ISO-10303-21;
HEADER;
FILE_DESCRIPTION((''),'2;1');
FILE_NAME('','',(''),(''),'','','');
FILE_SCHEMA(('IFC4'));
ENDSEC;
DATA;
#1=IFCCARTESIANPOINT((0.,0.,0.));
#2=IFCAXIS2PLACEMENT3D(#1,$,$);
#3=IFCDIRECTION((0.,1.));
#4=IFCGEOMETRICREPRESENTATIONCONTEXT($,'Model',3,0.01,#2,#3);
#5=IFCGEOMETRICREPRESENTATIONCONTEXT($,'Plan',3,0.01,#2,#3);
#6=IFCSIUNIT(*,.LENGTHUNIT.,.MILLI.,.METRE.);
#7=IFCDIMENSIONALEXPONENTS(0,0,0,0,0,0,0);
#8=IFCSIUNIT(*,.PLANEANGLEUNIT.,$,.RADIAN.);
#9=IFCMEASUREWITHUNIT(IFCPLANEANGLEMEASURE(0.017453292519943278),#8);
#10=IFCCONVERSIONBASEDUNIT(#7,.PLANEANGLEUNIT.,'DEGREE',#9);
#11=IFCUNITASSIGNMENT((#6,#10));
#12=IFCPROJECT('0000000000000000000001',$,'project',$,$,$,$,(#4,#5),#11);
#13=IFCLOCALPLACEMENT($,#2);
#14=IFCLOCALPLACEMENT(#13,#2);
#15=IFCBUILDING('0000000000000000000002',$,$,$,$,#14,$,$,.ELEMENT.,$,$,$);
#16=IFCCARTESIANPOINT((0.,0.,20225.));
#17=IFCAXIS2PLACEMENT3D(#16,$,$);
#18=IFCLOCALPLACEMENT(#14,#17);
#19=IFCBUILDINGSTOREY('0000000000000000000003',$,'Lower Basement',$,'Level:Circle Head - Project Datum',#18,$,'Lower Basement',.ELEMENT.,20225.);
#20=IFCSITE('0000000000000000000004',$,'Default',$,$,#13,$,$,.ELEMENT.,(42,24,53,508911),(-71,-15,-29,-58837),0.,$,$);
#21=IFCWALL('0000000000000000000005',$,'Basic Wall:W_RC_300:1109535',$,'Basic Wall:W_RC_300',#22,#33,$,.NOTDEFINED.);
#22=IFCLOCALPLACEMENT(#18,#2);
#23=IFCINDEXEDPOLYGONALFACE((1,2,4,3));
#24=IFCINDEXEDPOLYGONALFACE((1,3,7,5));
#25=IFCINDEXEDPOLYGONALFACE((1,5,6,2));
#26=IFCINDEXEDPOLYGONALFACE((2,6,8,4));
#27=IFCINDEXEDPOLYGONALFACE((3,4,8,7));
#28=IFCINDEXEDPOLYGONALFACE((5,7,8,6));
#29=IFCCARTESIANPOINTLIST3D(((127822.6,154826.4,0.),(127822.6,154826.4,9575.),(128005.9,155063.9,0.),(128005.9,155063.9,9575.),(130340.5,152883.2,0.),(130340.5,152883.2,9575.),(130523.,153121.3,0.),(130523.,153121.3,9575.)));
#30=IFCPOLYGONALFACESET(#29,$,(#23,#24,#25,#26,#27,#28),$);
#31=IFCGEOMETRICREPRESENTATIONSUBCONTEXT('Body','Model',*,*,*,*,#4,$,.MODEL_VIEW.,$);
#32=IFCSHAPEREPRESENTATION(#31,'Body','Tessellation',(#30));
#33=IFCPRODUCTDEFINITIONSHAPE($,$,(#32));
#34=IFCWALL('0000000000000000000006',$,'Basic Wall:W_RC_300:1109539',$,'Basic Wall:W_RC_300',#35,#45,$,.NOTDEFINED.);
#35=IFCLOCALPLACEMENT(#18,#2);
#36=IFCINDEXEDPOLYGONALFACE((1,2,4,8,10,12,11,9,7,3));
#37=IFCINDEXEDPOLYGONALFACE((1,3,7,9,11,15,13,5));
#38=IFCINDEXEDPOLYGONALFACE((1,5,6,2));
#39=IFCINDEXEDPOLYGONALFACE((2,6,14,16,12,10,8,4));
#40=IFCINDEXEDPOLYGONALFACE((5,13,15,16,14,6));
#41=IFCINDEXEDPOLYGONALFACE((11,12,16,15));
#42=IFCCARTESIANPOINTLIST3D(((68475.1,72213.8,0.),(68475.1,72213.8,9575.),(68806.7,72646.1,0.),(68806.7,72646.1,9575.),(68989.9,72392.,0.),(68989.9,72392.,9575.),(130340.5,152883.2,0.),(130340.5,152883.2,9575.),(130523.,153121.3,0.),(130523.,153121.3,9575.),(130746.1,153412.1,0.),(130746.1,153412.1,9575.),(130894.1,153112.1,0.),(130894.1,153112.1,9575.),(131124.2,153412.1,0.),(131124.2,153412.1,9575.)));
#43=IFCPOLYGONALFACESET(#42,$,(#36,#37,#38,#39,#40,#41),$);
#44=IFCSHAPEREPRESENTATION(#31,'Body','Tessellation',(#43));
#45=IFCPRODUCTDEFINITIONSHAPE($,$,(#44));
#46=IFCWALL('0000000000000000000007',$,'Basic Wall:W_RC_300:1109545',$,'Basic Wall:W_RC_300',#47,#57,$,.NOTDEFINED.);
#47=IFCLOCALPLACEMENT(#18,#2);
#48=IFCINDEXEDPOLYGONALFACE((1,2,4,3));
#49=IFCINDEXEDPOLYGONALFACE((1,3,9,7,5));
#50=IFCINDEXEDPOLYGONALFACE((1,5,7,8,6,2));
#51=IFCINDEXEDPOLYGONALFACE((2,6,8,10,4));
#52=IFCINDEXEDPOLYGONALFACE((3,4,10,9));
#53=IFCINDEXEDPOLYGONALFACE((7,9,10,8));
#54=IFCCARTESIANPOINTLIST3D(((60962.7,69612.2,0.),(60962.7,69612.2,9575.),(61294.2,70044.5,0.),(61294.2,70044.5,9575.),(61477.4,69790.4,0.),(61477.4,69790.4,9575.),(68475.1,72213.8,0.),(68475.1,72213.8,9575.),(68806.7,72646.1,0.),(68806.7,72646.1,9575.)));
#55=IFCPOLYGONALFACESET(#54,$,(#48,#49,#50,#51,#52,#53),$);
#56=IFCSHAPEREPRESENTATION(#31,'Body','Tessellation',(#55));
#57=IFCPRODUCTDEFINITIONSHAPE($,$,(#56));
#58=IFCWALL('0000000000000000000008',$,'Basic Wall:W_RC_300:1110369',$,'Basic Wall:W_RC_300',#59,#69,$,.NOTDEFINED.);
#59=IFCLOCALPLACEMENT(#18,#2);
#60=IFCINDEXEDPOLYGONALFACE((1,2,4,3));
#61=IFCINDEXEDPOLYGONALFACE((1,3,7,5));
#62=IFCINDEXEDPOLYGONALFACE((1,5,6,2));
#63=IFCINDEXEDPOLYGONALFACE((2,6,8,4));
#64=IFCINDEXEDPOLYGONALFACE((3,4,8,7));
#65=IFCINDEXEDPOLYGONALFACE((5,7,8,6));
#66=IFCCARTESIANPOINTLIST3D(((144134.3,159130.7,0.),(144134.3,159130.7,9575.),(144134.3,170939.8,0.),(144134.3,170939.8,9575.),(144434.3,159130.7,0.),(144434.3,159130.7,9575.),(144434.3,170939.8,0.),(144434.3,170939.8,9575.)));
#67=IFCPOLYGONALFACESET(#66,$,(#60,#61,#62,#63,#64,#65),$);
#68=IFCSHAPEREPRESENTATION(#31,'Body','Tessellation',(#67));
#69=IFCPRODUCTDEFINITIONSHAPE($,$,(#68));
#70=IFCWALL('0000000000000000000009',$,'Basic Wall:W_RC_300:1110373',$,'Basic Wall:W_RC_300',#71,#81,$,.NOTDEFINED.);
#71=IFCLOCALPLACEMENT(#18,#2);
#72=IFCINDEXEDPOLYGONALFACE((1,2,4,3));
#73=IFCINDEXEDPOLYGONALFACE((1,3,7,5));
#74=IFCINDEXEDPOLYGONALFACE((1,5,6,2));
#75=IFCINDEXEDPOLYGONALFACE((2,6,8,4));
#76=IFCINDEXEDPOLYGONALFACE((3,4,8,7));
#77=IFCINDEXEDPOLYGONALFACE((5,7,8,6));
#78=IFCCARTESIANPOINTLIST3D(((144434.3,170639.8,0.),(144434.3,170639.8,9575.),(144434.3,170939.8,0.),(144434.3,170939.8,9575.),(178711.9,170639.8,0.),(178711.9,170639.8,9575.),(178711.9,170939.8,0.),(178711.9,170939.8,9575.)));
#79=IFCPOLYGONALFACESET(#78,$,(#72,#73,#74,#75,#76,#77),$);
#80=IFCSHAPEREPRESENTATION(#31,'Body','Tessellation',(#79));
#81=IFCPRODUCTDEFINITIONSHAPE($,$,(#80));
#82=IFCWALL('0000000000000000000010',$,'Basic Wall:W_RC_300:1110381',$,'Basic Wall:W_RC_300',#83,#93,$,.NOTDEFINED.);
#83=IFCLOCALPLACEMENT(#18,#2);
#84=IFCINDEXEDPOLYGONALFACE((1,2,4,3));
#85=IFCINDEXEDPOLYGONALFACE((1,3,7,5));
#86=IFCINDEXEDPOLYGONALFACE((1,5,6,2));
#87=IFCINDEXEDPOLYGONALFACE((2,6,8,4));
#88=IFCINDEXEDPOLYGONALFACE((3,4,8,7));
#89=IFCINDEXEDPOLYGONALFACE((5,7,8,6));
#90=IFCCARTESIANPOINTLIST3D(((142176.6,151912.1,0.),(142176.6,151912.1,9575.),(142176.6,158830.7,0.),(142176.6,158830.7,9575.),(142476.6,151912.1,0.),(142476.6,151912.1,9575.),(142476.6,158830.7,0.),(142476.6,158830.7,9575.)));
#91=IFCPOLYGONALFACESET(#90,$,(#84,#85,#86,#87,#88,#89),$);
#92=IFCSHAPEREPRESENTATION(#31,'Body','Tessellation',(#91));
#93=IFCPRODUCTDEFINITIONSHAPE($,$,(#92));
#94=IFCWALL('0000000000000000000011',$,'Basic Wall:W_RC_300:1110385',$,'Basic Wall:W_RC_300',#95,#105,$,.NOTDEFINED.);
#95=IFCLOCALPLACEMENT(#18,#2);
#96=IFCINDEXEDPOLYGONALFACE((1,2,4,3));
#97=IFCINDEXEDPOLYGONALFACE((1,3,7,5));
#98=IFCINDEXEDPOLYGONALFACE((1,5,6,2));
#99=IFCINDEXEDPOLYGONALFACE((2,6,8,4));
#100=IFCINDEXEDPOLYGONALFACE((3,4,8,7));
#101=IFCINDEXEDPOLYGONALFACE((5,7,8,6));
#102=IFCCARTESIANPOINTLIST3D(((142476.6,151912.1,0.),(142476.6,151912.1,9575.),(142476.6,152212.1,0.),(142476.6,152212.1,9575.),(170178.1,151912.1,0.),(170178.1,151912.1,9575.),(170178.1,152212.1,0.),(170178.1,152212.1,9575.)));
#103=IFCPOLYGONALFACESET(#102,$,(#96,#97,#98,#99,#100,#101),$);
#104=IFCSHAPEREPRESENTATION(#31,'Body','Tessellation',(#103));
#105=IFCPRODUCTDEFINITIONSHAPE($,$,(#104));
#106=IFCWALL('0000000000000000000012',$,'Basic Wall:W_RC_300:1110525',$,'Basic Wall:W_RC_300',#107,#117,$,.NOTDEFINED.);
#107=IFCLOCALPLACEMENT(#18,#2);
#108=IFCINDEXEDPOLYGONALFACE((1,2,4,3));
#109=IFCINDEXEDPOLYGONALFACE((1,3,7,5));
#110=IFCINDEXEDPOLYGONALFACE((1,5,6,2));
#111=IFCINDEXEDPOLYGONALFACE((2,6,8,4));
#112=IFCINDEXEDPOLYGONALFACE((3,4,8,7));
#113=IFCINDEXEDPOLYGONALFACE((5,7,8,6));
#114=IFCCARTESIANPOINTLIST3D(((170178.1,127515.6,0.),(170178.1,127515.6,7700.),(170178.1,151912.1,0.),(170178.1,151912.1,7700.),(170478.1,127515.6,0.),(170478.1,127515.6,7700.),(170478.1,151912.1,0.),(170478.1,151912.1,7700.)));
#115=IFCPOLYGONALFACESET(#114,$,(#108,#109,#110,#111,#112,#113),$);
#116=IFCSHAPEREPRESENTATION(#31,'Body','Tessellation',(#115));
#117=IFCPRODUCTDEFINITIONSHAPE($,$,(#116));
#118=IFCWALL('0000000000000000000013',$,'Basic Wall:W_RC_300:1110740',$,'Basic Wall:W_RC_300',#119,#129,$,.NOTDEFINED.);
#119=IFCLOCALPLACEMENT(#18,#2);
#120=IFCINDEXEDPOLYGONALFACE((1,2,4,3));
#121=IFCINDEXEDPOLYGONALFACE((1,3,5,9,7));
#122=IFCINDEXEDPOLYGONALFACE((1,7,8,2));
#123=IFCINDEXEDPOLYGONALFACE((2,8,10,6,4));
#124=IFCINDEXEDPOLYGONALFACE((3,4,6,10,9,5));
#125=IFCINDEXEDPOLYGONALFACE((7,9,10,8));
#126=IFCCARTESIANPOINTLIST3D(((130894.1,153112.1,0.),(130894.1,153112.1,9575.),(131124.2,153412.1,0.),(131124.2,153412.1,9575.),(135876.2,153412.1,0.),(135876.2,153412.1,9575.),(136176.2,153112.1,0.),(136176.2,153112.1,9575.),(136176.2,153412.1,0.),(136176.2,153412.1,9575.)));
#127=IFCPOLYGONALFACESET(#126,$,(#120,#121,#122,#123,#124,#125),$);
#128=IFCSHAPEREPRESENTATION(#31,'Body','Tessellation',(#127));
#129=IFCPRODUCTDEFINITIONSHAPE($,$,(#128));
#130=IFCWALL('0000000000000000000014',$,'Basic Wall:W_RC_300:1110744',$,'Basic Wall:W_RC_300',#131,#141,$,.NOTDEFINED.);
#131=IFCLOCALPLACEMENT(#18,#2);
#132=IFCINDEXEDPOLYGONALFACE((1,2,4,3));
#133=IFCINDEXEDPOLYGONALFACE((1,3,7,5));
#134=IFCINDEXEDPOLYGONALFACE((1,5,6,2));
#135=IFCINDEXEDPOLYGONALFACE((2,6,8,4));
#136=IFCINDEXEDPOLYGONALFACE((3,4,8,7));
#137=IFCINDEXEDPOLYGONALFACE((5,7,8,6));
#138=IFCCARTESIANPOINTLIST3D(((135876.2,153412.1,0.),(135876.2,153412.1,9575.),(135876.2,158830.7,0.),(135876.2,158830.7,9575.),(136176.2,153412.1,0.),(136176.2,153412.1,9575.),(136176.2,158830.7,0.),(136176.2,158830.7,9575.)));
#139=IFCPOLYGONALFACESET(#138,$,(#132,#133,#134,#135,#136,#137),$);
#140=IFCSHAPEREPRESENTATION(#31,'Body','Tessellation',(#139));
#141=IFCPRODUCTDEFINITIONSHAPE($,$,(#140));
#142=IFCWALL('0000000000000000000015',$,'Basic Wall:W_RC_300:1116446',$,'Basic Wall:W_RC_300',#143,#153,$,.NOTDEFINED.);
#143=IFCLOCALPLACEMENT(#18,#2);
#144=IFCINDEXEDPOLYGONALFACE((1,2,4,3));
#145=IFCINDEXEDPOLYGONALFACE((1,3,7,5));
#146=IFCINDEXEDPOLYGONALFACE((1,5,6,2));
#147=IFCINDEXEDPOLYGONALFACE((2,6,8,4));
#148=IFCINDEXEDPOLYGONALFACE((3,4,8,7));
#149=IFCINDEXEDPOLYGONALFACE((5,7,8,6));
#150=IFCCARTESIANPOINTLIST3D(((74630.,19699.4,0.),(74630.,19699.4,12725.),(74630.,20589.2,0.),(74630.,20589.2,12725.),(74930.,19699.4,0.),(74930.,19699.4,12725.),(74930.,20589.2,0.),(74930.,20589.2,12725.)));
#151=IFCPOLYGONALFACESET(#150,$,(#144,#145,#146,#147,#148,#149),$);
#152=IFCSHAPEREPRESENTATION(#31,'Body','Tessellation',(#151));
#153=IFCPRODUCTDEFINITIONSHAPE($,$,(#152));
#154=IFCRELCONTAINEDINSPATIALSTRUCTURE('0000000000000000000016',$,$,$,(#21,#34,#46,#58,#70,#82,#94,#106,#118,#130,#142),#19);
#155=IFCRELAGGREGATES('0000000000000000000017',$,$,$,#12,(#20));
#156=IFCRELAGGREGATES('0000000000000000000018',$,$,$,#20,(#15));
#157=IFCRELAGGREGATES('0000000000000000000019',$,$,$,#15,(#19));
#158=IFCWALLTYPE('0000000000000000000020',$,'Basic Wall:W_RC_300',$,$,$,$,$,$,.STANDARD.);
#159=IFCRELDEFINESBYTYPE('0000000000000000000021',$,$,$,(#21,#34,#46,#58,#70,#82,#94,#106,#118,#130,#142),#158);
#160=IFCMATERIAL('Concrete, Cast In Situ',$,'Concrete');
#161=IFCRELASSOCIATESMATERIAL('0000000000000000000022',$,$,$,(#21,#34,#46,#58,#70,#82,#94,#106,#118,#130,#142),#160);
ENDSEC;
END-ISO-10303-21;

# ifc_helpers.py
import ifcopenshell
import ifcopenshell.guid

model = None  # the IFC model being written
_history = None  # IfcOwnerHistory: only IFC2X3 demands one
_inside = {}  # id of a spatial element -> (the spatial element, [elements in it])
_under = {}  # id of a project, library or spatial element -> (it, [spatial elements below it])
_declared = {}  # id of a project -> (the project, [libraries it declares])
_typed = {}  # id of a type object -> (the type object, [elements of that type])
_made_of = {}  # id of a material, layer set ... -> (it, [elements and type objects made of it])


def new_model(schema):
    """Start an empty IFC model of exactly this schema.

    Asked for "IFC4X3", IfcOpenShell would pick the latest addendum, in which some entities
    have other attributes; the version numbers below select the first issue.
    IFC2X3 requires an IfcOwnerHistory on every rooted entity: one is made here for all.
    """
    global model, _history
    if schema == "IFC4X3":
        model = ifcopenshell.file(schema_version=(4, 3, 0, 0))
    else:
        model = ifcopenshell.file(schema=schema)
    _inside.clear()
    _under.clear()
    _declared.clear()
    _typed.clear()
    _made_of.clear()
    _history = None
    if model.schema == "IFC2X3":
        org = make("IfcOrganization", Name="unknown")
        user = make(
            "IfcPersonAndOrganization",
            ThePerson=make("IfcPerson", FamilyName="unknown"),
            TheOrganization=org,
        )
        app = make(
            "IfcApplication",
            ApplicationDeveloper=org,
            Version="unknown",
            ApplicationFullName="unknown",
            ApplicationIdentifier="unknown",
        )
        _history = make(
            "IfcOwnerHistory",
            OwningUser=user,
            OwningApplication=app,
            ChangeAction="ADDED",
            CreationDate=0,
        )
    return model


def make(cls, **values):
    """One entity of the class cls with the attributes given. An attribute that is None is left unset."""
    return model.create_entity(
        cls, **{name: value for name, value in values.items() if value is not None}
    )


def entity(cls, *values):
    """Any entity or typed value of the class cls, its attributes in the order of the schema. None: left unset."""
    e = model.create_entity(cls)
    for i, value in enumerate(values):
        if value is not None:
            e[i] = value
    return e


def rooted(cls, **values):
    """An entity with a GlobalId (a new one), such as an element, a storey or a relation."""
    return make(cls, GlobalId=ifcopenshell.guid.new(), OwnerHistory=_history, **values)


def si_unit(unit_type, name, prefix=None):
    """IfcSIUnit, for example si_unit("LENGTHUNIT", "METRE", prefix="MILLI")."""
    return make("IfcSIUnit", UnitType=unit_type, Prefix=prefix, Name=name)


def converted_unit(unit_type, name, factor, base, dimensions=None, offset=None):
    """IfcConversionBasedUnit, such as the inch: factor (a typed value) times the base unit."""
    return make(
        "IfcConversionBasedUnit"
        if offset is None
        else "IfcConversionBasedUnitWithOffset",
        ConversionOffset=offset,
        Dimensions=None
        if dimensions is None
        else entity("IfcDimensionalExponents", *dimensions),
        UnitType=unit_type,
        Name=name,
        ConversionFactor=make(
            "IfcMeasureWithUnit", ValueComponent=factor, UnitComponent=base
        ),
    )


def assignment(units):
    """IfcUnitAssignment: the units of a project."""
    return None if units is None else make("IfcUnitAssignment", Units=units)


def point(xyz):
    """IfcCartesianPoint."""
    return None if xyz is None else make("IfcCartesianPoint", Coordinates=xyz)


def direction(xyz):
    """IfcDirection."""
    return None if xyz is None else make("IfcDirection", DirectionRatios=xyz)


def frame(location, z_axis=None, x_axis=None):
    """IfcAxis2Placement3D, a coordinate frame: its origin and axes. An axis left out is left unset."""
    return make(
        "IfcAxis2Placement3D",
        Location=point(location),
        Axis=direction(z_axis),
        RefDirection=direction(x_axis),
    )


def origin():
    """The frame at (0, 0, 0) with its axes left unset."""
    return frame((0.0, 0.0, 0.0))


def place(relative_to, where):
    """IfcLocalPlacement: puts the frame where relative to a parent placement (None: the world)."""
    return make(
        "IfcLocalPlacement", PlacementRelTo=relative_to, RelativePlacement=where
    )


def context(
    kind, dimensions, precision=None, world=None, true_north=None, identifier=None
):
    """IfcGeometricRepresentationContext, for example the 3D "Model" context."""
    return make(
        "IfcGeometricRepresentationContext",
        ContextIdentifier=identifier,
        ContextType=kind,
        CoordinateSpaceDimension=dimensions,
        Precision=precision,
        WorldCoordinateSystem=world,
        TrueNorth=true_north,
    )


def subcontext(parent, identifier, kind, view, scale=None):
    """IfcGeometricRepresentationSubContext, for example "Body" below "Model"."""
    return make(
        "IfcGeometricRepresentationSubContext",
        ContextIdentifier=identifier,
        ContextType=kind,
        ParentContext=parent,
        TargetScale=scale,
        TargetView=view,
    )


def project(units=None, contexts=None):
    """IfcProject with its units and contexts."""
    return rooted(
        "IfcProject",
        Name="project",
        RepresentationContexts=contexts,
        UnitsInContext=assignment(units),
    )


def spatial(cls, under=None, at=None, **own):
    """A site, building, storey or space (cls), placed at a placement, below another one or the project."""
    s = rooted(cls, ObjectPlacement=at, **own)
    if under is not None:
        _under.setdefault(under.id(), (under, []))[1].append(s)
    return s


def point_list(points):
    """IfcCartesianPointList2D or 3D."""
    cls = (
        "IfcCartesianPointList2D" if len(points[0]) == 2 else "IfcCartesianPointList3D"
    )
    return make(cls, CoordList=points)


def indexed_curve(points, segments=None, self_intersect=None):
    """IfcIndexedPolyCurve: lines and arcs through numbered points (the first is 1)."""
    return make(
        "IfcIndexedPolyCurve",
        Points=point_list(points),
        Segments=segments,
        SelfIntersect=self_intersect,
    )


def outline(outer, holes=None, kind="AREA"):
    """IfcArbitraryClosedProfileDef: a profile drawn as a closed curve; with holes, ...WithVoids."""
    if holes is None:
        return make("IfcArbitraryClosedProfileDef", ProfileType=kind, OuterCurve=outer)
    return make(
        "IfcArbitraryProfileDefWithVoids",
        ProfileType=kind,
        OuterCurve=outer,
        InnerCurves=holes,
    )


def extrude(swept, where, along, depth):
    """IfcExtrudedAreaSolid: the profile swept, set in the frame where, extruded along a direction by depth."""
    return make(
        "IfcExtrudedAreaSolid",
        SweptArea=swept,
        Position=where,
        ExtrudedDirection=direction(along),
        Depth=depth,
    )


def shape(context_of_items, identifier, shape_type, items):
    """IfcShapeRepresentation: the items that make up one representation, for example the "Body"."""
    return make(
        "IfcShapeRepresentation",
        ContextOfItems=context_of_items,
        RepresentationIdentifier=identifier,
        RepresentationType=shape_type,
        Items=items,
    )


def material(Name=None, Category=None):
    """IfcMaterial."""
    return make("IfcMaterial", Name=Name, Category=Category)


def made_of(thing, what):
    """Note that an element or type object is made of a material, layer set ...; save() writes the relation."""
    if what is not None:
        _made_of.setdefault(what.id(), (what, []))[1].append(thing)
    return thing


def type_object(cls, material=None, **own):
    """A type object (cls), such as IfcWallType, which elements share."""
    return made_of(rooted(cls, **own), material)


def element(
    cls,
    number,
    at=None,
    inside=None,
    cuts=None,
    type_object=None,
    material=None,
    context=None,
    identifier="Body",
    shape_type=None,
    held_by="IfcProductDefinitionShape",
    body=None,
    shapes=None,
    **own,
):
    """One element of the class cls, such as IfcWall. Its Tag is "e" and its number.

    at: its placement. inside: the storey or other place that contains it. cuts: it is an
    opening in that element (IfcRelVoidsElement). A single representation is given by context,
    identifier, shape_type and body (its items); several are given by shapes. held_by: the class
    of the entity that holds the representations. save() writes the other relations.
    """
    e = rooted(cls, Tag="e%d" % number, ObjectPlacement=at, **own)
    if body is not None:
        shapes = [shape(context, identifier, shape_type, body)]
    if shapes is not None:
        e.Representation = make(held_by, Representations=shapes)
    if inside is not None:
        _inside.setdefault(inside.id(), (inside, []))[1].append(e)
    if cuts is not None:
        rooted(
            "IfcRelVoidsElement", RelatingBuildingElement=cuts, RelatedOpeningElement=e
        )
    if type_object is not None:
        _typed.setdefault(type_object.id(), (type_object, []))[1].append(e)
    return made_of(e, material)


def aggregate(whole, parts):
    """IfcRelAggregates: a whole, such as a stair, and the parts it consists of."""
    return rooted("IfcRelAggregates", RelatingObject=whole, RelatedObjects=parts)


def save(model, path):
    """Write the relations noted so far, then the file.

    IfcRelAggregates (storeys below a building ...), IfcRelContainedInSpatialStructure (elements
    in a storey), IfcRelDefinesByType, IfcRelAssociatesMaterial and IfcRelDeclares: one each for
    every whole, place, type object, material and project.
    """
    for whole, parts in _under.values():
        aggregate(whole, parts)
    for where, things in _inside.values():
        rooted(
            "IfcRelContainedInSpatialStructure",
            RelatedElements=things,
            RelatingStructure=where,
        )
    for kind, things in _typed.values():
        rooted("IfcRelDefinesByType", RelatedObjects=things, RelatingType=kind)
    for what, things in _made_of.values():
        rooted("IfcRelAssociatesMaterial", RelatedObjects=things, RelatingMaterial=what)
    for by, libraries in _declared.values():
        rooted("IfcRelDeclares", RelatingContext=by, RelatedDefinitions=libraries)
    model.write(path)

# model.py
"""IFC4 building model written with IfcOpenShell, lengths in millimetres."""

from ifc_helpers import new_model, entity, si_unit, converted_unit, direction, frame, origin, place, context, subcontext, project, spatial, indexed_curve, outline, extrude, material, type_object, element, save


model = new_model("IFC4")

# Units and contexts
model_context = context("Model", 3, precision=0.01, world=origin(), true_north=direction((0.0, 1.0)))
plan_context = context("Plan", 3, precision=0.01, world=origin(), true_north=direction((0.0, 1.0)))
body_context = subcontext(model_context, "Body", "Model", "MODEL_VIEW")
ifc_project = project(units=[si_unit("LENGTHUNIT", "METRE", prefix="MILLI"), converted_unit("PLANEANGLEUNIT", "DEGREE", entity("IfcPlaneAngleMeasure", 0.017453292519943278), si_unit("PLANEANGLEUNIT", "RADIAN"), dimensions=[0, 0, 0, 0, 0, 0, 0])], contexts=[model_context, plan_context])

# Site, building, storey
site_placement = place(None, origin())
site = spatial("IfcSite", under=ifc_project, at=site_placement, Name="Default", CompositionType="ELEMENT", RefLatitude=(42, 24, 53, 508911), RefLongitude=(-71, -15, -29, -58837), RefElevation=0.0)
building_placement = place(site_placement, origin())
building = spatial("IfcBuilding", under=site, at=building_placement, CompositionType="ELEMENT")
storey_placement = place(building_placement, frame((0.0, 0.0, 20225.0)))
storey = spatial("IfcBuildingStorey", under=building, at=storey_placement, Name="Lower Basement", ObjectType="Level:Circle Head - Project Datum", LongName="Lower Basement", CompositionType="ELEMENT", Elevation=20225.0)

# Walls
ifc_material_1 = material(Name="Concrete, Cast In Situ", Category="Concrete")
wall_type_1 = type_object("IfcWallType", Name="Basic Wall:W_RC_300", PredefinedType="STANDARD")
wall_1_placement = place(storey_placement, frame((130432.1, 153001.9, 0.0), z_axis=(0.0, 0.0, 1.0), x_axis=(-0.791654, 0.61097, 0.0)))
element("IfcWall", 1, at=wall_1_placement, inside=storey, type_object=wall_type_1, material=ifc_material_1, Name="Basic Wall:W_RC_300:1109535", ObjectType="Basic Wall:W_RC_300", PredefinedType="NOTDEFINED", context=body_context, shape_type="SweptSolid", body=[
    extrude(outline(indexed_curve([(3180.5, -150.0), (3180.5, 150.0), (0.0, 150.0), (0.9, -150.0), (3180.5, -150.0)], self_intersect=False)), origin(), (0.0, 0.0, 1.0), 9575.0),
])
wall_2_placement = place(storey_placement, frame((68594.2, 72122.5, 0.0), z_axis=(0.0, 0.0, 1.0), x_axis=(0.608548, 0.793517, 0.0)))
element("IfcWall", 2, at=wall_2_placement, inside=storey, type_object=wall_type_1, material=ifc_material_1, Name="Basic Wall:W_RC_300:1109539", ObjectType="Basic Wall:W_RC_300", PredefinedType="NOTDEFINED", context=body_context, shape_type="SweptSolid", body=[
    extrude(outline(indexed_curve([(102557.2, -150.0), (102327.2, 150.0), (101960.6, 150.0), (101660.6, 150.0), (544.8, 150.0), (0.0, 150.0), (454.7, -150.0), (102179.2, -150.0), (102557.2, -150.0)], self_intersect=False)), origin(), (0.0, 0.0, 1.0), 9575.0),
])
wall_3_placement = place(storey_placement, frame((60913.6, 69753.9, 0.0), z_axis=(0.0, 0.0, 1.0), x_axis=(0.944942, 0.327236, 0.0)))
element("IfcWall", 3, at=wall_3_placement, inside=storey, type_object=wall_type_1, material=ifc_material_1, Name="Basic Wall:W_RC_300:1109545", ObjectType="Basic Wall:W_RC_300", PredefinedType="NOTDEFINED", context=body_context, shape_type="SweptSolid", body=[
    extrude(outline(indexed_curve([(7950.2, -150.0), (8404.9, 150.0), (454.7, 150.0), (0.0, -150.0), (544.7, -150.0), (7950.2, -150.0)], self_intersect=False)), origin(), (0.0, 0.0, 1.0), 9575.0),
])
wall_4_placement = place(storey_placement, frame((144284.3, 159130.7, 0.0), z_axis=(0.0, 0.0, 1.0), x_axis=(0.0, 1.0, 0.0)))
element("IfcWall", 4, at=wall_4_placement, inside=storey, type_object=wall_type_1, material=ifc_material_1, Name="Basic Wall:W_RC_300:1110369", ObjectType="Basic Wall:W_RC_300", PredefinedType="NOTDEFINED", context=body_context, shape_type="SweptSolid", body=[
    extrude(outline(indexed_curve([(11809.1, 150.0), (0.0, 150.0), (0.0, -150.0), (11809.1, -150.0), (11809.1, 150.0)], self_intersect=False)), origin(), (0.0, 0.0, 1.0), 9575.0),
])
wall_5_placement = place(storey_placement, frame((144434.3, 170789.8, 0.0)))
element("IfcWall", 5, at=wall_5_placement, inside=storey, type_object=wall_type_1, material=ifc_material_1, Name="Basic Wall:W_RC_300:1110373", ObjectType="Basic Wall:W_RC_300", PredefinedType="NOTDEFINED", context=body_context, shape_type="SweptSolid", body=[
    extrude(outline(indexed_curve([(34277.6, 150.0), (0.0, 150.0), (0.0, -150.0), (34277.6, -150.0), (34277.6, 150.0)], self_intersect=False)), origin(), (0.0, 0.0, 1.0), 9575.0),
])
wall_6_placement = place(storey_placement, frame((142326.6, 151912.1, 0.0), z_axis=(0.0, 0.0, 1.0), x_axis=(0.0, 1.0, 0.0)))
element("IfcWall", 6, at=wall_6_placement, inside=storey, type_object=wall_type_1, material=ifc_material_1, Name="Basic Wall:W_RC_300:1110381", ObjectType="Basic Wall:W_RC_300", PredefinedType="NOTDEFINED", context=body_context, shape_type="SweptSolid", body=[
    extrude(outline(indexed_curve([(6918.6, 150.0), (0.0, 150.0), (0.0, -150.0), (6918.6, -150.0), (6918.6, 150.0)], self_intersect=False)), origin(), (0.0, 0.0, 1.0), 9575.0),
])
wall_7_placement = place(storey_placement, frame((170178.1, 152062.1, 0.0), z_axis=(0.0, 0.0, 1.0), x_axis=(-1.0, 0.0, 0.0)))
element("IfcWall", 7, at=wall_7_placement, inside=storey, type_object=wall_type_1, material=ifc_material_1, Name="Basic Wall:W_RC_300:1110385", ObjectType="Basic Wall:W_RC_300", PredefinedType="NOTDEFINED", context=body_context, shape_type="SweptSolid", body=[
    extrude(outline(indexed_curve([(27701.5, 150.0), (0.0, 150.0), (0.0, -150.0), (27701.5, -150.0), (27701.5, 150.0)], self_intersect=False)), origin(), (0.0, 0.0, 1.0), 9575.0),
])
wall_8_placement = place(storey_placement, frame((170328.1, 127515.6, 0.0), z_axis=(0.0, 0.0, 1.0), x_axis=(0.0, 1.0, 0.0)))
element("IfcWall", 8, at=wall_8_placement, inside=storey, type_object=wall_type_1, material=ifc_material_1, Name="Basic Wall:W_RC_300:1110525", ObjectType="Basic Wall:W_RC_300", PredefinedType="NOTDEFINED", context=body_context, shape_type="SweptSolid", body=[
    extrude(outline(indexed_curve([(24396.6, 150.0), (0.0, 150.0), (0.0, -150.0), (24396.6, -150.0), (24396.6, 150.0)], self_intersect=False)), origin(), (0.0, 0.0, 1.0), 7700.0),
])
wall_9_placement = place(storey_placement, frame((136176.2, 153262.1, 0.0), z_axis=(0.0, 0.0, 1.0), x_axis=(-1.0, 0.0, 0.0)))
element("IfcWall", 9, at=wall_9_placement, inside=storey, type_object=wall_type_1, material=ifc_material_1, Name="Basic Wall:W_RC_300:1110740", ObjectType="Basic Wall:W_RC_300", PredefinedType="NOTDEFINED", context=body_context, shape_type="SweptSolid", body=[
    extrude(outline(indexed_curve([(5052.0, -150.0), (5282.1, 150.0), (0.0, 150.0), (0.0, -150.0), (300.0, -150.0), (5052.0, -150.0)], self_intersect=False)), origin(), (0.0, 0.0, 1.0), 9575.0),
])
wall_10_placement = place(storey_placement, frame((136026.2, 158830.7, 0.0), z_axis=(0.0, 0.0, 1.0), x_axis=(0.0, -1.0, 0.0)))
element("IfcWall", 10, at=wall_10_placement, inside=storey, type_object=wall_type_1, material=ifc_material_1, Name="Basic Wall:W_RC_300:1110744", ObjectType="Basic Wall:W_RC_300", PredefinedType="NOTDEFINED", context=body_context, shape_type="SweptSolid", body=[
    extrude(outline(indexed_curve([(5418.6, 150.0), (0.0, 150.0), (0.0, -150.0), (5418.6, -150.0), (5418.6, 150.0)], self_intersect=False)), origin(), (0.0, 0.0, 1.0), 9575.0),
])
wall_11_placement = place(storey_placement, frame((74780.0, 20589.2, 0.0), z_axis=(0.0, 0.0, 1.0), x_axis=(0.0, -1.0, 0.0)))
element("IfcWall", 11, at=wall_11_placement, inside=storey, type_object=wall_type_1, material=ifc_material_1, Name="Basic Wall:W_RC_300:1116446", ObjectType="Basic Wall:W_RC_300", PredefinedType="NOTDEFINED", context=body_context, shape_type="SweptSolid", body=[
    extrude(outline(indexed_curve([(889.8, 150.0), (0.0, 150.0), (0.0, -150.0), (889.8, -150.0), (889.8, 150.0)], self_intersect=False)), origin(), (0.0, 0.0, 1.0), 12725.0),
])

save(model, "model.ifc")
